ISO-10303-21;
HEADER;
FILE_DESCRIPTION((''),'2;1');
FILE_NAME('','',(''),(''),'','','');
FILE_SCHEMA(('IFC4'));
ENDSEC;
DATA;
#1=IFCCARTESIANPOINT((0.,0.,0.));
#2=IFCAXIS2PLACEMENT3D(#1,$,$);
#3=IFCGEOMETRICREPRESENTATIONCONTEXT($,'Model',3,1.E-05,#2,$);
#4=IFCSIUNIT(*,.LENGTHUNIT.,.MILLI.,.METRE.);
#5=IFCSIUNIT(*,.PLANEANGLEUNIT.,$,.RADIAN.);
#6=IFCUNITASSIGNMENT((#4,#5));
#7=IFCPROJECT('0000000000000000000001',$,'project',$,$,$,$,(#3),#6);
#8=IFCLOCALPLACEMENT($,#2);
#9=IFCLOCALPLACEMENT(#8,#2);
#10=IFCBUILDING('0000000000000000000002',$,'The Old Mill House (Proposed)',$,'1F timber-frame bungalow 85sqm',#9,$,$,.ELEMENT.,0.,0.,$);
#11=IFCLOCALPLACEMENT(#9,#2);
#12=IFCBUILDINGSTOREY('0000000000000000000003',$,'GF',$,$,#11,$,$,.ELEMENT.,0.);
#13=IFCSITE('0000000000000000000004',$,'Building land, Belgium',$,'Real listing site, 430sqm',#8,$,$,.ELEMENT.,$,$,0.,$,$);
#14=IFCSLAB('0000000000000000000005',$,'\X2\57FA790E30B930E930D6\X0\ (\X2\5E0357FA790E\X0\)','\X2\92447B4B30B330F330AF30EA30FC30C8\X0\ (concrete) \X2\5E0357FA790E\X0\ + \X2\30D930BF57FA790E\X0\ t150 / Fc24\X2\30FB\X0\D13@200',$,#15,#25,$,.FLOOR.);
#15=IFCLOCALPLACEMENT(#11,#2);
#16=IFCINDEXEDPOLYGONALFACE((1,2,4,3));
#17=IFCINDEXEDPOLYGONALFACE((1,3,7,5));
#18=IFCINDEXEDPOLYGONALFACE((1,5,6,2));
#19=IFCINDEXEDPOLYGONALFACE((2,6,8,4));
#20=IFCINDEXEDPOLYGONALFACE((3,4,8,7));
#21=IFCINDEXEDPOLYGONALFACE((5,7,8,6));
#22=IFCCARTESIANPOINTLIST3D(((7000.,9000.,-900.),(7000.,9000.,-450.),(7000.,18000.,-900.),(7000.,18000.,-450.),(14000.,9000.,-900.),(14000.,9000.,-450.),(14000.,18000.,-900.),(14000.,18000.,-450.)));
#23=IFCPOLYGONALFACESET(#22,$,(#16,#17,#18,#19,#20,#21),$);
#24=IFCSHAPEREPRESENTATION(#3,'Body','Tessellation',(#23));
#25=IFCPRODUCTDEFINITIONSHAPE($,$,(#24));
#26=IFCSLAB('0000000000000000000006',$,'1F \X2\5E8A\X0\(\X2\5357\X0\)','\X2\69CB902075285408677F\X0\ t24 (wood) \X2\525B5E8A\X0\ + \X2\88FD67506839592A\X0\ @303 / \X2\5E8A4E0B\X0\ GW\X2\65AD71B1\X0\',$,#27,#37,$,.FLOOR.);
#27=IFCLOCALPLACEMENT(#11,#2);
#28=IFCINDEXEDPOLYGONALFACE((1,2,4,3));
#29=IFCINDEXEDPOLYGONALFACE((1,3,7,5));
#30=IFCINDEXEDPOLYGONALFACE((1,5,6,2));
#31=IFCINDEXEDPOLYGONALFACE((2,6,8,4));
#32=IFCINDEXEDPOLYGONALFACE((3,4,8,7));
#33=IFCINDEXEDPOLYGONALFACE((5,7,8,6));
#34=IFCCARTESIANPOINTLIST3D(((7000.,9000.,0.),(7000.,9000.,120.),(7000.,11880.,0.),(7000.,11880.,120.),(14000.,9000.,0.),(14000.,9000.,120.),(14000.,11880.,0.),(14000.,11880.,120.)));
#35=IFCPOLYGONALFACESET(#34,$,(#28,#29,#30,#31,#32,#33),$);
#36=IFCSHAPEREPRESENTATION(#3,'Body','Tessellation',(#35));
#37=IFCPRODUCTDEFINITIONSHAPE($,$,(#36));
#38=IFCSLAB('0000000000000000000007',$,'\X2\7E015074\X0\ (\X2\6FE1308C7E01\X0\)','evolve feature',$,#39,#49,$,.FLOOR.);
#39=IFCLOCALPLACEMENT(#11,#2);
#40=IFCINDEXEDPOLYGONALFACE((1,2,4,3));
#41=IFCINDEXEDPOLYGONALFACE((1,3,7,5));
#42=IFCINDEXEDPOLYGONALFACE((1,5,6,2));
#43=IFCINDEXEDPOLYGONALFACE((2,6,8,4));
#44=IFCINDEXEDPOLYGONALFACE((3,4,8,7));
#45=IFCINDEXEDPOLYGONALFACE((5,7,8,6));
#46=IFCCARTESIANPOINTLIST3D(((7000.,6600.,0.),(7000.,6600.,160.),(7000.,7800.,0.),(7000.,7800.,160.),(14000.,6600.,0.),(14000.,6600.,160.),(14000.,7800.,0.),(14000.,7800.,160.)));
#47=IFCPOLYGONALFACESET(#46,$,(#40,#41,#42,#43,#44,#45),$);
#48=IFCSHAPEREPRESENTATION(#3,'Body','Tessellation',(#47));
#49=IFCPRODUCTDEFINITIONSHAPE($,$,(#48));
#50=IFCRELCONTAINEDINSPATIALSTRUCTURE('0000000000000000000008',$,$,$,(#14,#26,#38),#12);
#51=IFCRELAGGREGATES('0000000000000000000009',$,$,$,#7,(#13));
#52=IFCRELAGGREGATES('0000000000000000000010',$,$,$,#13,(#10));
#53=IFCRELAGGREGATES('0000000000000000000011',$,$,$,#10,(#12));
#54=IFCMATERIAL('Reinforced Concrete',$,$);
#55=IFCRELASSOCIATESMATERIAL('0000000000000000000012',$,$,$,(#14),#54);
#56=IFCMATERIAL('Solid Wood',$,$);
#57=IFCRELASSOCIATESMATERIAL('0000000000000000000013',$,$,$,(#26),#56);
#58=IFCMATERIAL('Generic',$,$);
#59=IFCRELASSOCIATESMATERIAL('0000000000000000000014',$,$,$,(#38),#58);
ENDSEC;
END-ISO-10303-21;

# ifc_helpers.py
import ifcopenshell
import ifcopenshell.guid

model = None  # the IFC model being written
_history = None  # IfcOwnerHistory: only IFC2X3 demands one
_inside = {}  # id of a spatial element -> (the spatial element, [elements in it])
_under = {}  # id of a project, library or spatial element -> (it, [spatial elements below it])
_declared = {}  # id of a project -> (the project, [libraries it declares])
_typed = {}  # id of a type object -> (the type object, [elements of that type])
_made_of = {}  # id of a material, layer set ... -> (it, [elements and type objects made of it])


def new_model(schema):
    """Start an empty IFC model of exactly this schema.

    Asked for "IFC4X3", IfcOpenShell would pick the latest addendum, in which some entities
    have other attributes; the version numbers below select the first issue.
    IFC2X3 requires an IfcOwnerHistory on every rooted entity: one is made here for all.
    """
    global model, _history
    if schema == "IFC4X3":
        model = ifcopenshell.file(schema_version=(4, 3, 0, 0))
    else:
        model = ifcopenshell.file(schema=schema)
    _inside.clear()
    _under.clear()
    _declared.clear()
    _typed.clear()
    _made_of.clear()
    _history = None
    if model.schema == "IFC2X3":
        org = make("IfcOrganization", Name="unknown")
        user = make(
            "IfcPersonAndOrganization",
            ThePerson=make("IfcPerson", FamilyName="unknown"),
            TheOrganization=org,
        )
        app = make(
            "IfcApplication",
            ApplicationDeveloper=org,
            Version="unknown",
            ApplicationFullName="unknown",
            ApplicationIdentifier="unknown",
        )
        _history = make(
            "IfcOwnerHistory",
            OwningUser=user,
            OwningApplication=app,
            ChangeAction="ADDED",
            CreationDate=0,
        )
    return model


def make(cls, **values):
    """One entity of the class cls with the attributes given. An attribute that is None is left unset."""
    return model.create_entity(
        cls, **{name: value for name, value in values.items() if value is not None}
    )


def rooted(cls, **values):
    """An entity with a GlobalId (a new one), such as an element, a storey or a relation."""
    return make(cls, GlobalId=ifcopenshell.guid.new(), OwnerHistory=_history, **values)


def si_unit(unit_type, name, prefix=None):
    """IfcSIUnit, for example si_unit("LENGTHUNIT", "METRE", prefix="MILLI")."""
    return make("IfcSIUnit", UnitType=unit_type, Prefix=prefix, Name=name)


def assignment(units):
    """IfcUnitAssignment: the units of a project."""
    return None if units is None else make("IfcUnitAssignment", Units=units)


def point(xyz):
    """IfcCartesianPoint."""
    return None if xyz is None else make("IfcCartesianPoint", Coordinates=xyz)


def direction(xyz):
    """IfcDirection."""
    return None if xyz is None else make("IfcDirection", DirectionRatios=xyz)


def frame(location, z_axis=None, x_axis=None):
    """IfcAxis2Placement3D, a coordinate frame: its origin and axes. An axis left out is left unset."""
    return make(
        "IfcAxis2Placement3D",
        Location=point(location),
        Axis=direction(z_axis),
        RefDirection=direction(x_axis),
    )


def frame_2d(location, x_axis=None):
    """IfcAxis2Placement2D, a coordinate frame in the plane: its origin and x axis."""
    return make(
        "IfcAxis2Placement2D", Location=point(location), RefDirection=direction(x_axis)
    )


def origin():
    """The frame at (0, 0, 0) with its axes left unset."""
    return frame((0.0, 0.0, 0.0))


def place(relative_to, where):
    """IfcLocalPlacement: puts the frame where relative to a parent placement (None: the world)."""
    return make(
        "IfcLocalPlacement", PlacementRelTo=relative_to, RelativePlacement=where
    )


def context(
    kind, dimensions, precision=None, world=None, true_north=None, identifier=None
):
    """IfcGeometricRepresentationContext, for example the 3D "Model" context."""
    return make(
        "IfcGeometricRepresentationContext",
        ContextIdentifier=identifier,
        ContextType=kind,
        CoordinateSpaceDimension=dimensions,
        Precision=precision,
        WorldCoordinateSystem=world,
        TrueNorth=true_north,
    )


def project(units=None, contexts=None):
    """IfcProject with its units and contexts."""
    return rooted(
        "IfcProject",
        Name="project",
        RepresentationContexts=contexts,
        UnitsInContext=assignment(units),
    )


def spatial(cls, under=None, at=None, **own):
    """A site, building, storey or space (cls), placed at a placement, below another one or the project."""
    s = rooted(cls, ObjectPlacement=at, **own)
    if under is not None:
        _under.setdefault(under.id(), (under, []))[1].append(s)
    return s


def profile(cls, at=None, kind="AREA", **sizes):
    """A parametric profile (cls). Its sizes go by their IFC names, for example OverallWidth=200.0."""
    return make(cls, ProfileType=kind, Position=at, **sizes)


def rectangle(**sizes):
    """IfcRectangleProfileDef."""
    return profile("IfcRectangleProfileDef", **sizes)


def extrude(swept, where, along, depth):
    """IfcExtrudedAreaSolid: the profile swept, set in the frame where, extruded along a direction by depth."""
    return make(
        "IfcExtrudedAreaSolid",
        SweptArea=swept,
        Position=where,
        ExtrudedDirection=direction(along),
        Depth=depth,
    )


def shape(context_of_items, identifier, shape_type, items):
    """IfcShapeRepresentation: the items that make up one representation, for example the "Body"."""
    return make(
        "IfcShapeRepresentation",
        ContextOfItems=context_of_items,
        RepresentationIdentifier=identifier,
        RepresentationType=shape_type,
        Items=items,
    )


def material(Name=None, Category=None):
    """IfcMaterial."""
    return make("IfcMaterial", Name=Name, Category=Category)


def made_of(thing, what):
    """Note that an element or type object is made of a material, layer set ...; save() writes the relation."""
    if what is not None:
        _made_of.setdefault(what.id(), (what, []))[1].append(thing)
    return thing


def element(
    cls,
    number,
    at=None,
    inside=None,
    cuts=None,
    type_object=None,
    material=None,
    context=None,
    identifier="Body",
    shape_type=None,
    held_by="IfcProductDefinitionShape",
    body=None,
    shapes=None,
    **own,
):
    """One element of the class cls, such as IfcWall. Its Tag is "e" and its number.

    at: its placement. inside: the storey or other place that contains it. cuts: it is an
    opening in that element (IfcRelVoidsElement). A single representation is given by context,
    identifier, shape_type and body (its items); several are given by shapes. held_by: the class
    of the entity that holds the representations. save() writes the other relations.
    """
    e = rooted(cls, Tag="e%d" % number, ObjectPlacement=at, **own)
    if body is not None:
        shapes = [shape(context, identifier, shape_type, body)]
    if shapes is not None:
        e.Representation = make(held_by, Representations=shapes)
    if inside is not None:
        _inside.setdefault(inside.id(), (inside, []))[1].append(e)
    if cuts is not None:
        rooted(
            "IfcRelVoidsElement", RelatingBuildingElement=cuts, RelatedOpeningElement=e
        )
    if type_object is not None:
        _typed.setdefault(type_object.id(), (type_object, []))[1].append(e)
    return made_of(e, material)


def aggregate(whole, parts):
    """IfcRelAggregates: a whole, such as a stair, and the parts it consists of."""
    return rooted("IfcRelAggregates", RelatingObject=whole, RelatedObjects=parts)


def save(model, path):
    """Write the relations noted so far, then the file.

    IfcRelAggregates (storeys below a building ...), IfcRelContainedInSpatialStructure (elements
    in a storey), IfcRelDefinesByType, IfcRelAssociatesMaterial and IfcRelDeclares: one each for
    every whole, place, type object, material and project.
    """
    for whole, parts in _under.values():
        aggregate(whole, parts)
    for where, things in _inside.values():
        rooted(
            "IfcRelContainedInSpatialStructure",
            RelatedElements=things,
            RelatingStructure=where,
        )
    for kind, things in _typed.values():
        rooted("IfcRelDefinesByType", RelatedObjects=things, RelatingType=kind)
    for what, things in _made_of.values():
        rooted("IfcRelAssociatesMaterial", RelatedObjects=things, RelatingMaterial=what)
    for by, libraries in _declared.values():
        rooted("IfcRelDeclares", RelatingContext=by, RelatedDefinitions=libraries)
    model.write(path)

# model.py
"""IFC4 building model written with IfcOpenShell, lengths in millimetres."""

from ifc_helpers import new_model, si_unit, frame, frame_2d, origin, place, context, project, spatial, rectangle, extrude, material, element, save


model = new_model("IFC4")

# Units and contexts
model_context = context("Model", 3, precision=1e-05, world=origin())
ifc_project = project(units=[si_unit("LENGTHUNIT", "METRE", prefix="MILLI"), si_unit("PLANEANGLEUNIT", "RADIAN")], contexts=[model_context])

# Site, building, storey
site_placement = place(None, origin())
site = spatial("IfcSite", under=ifc_project, at=site_placement, Name="Building land, Belgium", ObjectType="Real listing site, 430sqm", CompositionType="ELEMENT", RefElevation=0.0)
building_placement = place(site_placement, origin())
building = spatial("IfcBuilding", under=site, at=building_placement, Name="The Old Mill House (Proposed)", ObjectType="1F timber-frame bungalow 85sqm", CompositionType="ELEMENT", ElevationOfRefHeight=0.0, ElevationOfTerrain=0.0)
storey_placement = place(building_placement, origin())
storey = spatial("IfcBuildingStorey", under=building, at=storey_placement, Name="GF", CompositionType="ELEMENT", Elevation=0.0)

# Slabs
ifc_material_1 = material(Name="Reinforced Concrete")
slab_1_placement = place(storey_placement, frame((3500.0, 4500.0, -450.0)))
element("IfcSlab", 1, at=slab_1_placement, inside=storey, material=ifc_material_1, Name="基礎スラブ (布基礎)", Description="鉄筋コンクリート (concrete) 布基礎 + ベタ基礎 t150 / Fc24・D13@200", PredefinedType="FLOOR", context=model_context, shape_type="SweptSolid", body=[
    extrude(rectangle(XDim=7000.0, YDim=9000.0, at=frame_2d((3500.0, 4500.0))), frame((3500.0, 4500.0, -450.0)), (0.0, 0.0, 1.0), 450.0),
])
ifc_material_2 = material(Name="Solid Wood")
slab_2_placement = place(storey_placement, frame((3500.0, 4500.0, 0.0)))
element("IfcSlab", 2, at=slab_2_placement, inside=storey, material=ifc_material_2, Name="1F 床(南)", Description="構造用合板 t24 (wood) 剛床 + 製材根太 @303 / 床下 GW断熱", PredefinedType="FLOOR", context=model_context, shape_type="SweptSolid", body=[
    extrude(rectangle(XDim=7000.0, YDim=2880.0, at=frame_2d((3500.0, 1440.0))), frame((3500.0, 4500.0, 0.0)), (0.0, 0.0, 1.0), 120.0),
])
ifc_material_3 = material(Name="Generic")
slab_3_placement = place(storey_placement, frame((3500.0, 3300.0, 0.0)))
element("IfcSlab", 3, at=slab_3_placement, inside=storey, material=ifc_material_3, Name="縁側 (濡れ縁)", Description="evolve feature", PredefinedType="FLOOR", context=model_context, shape_type="SweptSolid", body=[
    extrude(rectangle(XDim=7000.0, YDim=1200.0, at=frame_2d((3500.0, 600.0))), frame((3500.0, 3300.0, 0.0)), (0.0, 0.0, 1.0), 160.0),
])

save(model, "model.ifc")
